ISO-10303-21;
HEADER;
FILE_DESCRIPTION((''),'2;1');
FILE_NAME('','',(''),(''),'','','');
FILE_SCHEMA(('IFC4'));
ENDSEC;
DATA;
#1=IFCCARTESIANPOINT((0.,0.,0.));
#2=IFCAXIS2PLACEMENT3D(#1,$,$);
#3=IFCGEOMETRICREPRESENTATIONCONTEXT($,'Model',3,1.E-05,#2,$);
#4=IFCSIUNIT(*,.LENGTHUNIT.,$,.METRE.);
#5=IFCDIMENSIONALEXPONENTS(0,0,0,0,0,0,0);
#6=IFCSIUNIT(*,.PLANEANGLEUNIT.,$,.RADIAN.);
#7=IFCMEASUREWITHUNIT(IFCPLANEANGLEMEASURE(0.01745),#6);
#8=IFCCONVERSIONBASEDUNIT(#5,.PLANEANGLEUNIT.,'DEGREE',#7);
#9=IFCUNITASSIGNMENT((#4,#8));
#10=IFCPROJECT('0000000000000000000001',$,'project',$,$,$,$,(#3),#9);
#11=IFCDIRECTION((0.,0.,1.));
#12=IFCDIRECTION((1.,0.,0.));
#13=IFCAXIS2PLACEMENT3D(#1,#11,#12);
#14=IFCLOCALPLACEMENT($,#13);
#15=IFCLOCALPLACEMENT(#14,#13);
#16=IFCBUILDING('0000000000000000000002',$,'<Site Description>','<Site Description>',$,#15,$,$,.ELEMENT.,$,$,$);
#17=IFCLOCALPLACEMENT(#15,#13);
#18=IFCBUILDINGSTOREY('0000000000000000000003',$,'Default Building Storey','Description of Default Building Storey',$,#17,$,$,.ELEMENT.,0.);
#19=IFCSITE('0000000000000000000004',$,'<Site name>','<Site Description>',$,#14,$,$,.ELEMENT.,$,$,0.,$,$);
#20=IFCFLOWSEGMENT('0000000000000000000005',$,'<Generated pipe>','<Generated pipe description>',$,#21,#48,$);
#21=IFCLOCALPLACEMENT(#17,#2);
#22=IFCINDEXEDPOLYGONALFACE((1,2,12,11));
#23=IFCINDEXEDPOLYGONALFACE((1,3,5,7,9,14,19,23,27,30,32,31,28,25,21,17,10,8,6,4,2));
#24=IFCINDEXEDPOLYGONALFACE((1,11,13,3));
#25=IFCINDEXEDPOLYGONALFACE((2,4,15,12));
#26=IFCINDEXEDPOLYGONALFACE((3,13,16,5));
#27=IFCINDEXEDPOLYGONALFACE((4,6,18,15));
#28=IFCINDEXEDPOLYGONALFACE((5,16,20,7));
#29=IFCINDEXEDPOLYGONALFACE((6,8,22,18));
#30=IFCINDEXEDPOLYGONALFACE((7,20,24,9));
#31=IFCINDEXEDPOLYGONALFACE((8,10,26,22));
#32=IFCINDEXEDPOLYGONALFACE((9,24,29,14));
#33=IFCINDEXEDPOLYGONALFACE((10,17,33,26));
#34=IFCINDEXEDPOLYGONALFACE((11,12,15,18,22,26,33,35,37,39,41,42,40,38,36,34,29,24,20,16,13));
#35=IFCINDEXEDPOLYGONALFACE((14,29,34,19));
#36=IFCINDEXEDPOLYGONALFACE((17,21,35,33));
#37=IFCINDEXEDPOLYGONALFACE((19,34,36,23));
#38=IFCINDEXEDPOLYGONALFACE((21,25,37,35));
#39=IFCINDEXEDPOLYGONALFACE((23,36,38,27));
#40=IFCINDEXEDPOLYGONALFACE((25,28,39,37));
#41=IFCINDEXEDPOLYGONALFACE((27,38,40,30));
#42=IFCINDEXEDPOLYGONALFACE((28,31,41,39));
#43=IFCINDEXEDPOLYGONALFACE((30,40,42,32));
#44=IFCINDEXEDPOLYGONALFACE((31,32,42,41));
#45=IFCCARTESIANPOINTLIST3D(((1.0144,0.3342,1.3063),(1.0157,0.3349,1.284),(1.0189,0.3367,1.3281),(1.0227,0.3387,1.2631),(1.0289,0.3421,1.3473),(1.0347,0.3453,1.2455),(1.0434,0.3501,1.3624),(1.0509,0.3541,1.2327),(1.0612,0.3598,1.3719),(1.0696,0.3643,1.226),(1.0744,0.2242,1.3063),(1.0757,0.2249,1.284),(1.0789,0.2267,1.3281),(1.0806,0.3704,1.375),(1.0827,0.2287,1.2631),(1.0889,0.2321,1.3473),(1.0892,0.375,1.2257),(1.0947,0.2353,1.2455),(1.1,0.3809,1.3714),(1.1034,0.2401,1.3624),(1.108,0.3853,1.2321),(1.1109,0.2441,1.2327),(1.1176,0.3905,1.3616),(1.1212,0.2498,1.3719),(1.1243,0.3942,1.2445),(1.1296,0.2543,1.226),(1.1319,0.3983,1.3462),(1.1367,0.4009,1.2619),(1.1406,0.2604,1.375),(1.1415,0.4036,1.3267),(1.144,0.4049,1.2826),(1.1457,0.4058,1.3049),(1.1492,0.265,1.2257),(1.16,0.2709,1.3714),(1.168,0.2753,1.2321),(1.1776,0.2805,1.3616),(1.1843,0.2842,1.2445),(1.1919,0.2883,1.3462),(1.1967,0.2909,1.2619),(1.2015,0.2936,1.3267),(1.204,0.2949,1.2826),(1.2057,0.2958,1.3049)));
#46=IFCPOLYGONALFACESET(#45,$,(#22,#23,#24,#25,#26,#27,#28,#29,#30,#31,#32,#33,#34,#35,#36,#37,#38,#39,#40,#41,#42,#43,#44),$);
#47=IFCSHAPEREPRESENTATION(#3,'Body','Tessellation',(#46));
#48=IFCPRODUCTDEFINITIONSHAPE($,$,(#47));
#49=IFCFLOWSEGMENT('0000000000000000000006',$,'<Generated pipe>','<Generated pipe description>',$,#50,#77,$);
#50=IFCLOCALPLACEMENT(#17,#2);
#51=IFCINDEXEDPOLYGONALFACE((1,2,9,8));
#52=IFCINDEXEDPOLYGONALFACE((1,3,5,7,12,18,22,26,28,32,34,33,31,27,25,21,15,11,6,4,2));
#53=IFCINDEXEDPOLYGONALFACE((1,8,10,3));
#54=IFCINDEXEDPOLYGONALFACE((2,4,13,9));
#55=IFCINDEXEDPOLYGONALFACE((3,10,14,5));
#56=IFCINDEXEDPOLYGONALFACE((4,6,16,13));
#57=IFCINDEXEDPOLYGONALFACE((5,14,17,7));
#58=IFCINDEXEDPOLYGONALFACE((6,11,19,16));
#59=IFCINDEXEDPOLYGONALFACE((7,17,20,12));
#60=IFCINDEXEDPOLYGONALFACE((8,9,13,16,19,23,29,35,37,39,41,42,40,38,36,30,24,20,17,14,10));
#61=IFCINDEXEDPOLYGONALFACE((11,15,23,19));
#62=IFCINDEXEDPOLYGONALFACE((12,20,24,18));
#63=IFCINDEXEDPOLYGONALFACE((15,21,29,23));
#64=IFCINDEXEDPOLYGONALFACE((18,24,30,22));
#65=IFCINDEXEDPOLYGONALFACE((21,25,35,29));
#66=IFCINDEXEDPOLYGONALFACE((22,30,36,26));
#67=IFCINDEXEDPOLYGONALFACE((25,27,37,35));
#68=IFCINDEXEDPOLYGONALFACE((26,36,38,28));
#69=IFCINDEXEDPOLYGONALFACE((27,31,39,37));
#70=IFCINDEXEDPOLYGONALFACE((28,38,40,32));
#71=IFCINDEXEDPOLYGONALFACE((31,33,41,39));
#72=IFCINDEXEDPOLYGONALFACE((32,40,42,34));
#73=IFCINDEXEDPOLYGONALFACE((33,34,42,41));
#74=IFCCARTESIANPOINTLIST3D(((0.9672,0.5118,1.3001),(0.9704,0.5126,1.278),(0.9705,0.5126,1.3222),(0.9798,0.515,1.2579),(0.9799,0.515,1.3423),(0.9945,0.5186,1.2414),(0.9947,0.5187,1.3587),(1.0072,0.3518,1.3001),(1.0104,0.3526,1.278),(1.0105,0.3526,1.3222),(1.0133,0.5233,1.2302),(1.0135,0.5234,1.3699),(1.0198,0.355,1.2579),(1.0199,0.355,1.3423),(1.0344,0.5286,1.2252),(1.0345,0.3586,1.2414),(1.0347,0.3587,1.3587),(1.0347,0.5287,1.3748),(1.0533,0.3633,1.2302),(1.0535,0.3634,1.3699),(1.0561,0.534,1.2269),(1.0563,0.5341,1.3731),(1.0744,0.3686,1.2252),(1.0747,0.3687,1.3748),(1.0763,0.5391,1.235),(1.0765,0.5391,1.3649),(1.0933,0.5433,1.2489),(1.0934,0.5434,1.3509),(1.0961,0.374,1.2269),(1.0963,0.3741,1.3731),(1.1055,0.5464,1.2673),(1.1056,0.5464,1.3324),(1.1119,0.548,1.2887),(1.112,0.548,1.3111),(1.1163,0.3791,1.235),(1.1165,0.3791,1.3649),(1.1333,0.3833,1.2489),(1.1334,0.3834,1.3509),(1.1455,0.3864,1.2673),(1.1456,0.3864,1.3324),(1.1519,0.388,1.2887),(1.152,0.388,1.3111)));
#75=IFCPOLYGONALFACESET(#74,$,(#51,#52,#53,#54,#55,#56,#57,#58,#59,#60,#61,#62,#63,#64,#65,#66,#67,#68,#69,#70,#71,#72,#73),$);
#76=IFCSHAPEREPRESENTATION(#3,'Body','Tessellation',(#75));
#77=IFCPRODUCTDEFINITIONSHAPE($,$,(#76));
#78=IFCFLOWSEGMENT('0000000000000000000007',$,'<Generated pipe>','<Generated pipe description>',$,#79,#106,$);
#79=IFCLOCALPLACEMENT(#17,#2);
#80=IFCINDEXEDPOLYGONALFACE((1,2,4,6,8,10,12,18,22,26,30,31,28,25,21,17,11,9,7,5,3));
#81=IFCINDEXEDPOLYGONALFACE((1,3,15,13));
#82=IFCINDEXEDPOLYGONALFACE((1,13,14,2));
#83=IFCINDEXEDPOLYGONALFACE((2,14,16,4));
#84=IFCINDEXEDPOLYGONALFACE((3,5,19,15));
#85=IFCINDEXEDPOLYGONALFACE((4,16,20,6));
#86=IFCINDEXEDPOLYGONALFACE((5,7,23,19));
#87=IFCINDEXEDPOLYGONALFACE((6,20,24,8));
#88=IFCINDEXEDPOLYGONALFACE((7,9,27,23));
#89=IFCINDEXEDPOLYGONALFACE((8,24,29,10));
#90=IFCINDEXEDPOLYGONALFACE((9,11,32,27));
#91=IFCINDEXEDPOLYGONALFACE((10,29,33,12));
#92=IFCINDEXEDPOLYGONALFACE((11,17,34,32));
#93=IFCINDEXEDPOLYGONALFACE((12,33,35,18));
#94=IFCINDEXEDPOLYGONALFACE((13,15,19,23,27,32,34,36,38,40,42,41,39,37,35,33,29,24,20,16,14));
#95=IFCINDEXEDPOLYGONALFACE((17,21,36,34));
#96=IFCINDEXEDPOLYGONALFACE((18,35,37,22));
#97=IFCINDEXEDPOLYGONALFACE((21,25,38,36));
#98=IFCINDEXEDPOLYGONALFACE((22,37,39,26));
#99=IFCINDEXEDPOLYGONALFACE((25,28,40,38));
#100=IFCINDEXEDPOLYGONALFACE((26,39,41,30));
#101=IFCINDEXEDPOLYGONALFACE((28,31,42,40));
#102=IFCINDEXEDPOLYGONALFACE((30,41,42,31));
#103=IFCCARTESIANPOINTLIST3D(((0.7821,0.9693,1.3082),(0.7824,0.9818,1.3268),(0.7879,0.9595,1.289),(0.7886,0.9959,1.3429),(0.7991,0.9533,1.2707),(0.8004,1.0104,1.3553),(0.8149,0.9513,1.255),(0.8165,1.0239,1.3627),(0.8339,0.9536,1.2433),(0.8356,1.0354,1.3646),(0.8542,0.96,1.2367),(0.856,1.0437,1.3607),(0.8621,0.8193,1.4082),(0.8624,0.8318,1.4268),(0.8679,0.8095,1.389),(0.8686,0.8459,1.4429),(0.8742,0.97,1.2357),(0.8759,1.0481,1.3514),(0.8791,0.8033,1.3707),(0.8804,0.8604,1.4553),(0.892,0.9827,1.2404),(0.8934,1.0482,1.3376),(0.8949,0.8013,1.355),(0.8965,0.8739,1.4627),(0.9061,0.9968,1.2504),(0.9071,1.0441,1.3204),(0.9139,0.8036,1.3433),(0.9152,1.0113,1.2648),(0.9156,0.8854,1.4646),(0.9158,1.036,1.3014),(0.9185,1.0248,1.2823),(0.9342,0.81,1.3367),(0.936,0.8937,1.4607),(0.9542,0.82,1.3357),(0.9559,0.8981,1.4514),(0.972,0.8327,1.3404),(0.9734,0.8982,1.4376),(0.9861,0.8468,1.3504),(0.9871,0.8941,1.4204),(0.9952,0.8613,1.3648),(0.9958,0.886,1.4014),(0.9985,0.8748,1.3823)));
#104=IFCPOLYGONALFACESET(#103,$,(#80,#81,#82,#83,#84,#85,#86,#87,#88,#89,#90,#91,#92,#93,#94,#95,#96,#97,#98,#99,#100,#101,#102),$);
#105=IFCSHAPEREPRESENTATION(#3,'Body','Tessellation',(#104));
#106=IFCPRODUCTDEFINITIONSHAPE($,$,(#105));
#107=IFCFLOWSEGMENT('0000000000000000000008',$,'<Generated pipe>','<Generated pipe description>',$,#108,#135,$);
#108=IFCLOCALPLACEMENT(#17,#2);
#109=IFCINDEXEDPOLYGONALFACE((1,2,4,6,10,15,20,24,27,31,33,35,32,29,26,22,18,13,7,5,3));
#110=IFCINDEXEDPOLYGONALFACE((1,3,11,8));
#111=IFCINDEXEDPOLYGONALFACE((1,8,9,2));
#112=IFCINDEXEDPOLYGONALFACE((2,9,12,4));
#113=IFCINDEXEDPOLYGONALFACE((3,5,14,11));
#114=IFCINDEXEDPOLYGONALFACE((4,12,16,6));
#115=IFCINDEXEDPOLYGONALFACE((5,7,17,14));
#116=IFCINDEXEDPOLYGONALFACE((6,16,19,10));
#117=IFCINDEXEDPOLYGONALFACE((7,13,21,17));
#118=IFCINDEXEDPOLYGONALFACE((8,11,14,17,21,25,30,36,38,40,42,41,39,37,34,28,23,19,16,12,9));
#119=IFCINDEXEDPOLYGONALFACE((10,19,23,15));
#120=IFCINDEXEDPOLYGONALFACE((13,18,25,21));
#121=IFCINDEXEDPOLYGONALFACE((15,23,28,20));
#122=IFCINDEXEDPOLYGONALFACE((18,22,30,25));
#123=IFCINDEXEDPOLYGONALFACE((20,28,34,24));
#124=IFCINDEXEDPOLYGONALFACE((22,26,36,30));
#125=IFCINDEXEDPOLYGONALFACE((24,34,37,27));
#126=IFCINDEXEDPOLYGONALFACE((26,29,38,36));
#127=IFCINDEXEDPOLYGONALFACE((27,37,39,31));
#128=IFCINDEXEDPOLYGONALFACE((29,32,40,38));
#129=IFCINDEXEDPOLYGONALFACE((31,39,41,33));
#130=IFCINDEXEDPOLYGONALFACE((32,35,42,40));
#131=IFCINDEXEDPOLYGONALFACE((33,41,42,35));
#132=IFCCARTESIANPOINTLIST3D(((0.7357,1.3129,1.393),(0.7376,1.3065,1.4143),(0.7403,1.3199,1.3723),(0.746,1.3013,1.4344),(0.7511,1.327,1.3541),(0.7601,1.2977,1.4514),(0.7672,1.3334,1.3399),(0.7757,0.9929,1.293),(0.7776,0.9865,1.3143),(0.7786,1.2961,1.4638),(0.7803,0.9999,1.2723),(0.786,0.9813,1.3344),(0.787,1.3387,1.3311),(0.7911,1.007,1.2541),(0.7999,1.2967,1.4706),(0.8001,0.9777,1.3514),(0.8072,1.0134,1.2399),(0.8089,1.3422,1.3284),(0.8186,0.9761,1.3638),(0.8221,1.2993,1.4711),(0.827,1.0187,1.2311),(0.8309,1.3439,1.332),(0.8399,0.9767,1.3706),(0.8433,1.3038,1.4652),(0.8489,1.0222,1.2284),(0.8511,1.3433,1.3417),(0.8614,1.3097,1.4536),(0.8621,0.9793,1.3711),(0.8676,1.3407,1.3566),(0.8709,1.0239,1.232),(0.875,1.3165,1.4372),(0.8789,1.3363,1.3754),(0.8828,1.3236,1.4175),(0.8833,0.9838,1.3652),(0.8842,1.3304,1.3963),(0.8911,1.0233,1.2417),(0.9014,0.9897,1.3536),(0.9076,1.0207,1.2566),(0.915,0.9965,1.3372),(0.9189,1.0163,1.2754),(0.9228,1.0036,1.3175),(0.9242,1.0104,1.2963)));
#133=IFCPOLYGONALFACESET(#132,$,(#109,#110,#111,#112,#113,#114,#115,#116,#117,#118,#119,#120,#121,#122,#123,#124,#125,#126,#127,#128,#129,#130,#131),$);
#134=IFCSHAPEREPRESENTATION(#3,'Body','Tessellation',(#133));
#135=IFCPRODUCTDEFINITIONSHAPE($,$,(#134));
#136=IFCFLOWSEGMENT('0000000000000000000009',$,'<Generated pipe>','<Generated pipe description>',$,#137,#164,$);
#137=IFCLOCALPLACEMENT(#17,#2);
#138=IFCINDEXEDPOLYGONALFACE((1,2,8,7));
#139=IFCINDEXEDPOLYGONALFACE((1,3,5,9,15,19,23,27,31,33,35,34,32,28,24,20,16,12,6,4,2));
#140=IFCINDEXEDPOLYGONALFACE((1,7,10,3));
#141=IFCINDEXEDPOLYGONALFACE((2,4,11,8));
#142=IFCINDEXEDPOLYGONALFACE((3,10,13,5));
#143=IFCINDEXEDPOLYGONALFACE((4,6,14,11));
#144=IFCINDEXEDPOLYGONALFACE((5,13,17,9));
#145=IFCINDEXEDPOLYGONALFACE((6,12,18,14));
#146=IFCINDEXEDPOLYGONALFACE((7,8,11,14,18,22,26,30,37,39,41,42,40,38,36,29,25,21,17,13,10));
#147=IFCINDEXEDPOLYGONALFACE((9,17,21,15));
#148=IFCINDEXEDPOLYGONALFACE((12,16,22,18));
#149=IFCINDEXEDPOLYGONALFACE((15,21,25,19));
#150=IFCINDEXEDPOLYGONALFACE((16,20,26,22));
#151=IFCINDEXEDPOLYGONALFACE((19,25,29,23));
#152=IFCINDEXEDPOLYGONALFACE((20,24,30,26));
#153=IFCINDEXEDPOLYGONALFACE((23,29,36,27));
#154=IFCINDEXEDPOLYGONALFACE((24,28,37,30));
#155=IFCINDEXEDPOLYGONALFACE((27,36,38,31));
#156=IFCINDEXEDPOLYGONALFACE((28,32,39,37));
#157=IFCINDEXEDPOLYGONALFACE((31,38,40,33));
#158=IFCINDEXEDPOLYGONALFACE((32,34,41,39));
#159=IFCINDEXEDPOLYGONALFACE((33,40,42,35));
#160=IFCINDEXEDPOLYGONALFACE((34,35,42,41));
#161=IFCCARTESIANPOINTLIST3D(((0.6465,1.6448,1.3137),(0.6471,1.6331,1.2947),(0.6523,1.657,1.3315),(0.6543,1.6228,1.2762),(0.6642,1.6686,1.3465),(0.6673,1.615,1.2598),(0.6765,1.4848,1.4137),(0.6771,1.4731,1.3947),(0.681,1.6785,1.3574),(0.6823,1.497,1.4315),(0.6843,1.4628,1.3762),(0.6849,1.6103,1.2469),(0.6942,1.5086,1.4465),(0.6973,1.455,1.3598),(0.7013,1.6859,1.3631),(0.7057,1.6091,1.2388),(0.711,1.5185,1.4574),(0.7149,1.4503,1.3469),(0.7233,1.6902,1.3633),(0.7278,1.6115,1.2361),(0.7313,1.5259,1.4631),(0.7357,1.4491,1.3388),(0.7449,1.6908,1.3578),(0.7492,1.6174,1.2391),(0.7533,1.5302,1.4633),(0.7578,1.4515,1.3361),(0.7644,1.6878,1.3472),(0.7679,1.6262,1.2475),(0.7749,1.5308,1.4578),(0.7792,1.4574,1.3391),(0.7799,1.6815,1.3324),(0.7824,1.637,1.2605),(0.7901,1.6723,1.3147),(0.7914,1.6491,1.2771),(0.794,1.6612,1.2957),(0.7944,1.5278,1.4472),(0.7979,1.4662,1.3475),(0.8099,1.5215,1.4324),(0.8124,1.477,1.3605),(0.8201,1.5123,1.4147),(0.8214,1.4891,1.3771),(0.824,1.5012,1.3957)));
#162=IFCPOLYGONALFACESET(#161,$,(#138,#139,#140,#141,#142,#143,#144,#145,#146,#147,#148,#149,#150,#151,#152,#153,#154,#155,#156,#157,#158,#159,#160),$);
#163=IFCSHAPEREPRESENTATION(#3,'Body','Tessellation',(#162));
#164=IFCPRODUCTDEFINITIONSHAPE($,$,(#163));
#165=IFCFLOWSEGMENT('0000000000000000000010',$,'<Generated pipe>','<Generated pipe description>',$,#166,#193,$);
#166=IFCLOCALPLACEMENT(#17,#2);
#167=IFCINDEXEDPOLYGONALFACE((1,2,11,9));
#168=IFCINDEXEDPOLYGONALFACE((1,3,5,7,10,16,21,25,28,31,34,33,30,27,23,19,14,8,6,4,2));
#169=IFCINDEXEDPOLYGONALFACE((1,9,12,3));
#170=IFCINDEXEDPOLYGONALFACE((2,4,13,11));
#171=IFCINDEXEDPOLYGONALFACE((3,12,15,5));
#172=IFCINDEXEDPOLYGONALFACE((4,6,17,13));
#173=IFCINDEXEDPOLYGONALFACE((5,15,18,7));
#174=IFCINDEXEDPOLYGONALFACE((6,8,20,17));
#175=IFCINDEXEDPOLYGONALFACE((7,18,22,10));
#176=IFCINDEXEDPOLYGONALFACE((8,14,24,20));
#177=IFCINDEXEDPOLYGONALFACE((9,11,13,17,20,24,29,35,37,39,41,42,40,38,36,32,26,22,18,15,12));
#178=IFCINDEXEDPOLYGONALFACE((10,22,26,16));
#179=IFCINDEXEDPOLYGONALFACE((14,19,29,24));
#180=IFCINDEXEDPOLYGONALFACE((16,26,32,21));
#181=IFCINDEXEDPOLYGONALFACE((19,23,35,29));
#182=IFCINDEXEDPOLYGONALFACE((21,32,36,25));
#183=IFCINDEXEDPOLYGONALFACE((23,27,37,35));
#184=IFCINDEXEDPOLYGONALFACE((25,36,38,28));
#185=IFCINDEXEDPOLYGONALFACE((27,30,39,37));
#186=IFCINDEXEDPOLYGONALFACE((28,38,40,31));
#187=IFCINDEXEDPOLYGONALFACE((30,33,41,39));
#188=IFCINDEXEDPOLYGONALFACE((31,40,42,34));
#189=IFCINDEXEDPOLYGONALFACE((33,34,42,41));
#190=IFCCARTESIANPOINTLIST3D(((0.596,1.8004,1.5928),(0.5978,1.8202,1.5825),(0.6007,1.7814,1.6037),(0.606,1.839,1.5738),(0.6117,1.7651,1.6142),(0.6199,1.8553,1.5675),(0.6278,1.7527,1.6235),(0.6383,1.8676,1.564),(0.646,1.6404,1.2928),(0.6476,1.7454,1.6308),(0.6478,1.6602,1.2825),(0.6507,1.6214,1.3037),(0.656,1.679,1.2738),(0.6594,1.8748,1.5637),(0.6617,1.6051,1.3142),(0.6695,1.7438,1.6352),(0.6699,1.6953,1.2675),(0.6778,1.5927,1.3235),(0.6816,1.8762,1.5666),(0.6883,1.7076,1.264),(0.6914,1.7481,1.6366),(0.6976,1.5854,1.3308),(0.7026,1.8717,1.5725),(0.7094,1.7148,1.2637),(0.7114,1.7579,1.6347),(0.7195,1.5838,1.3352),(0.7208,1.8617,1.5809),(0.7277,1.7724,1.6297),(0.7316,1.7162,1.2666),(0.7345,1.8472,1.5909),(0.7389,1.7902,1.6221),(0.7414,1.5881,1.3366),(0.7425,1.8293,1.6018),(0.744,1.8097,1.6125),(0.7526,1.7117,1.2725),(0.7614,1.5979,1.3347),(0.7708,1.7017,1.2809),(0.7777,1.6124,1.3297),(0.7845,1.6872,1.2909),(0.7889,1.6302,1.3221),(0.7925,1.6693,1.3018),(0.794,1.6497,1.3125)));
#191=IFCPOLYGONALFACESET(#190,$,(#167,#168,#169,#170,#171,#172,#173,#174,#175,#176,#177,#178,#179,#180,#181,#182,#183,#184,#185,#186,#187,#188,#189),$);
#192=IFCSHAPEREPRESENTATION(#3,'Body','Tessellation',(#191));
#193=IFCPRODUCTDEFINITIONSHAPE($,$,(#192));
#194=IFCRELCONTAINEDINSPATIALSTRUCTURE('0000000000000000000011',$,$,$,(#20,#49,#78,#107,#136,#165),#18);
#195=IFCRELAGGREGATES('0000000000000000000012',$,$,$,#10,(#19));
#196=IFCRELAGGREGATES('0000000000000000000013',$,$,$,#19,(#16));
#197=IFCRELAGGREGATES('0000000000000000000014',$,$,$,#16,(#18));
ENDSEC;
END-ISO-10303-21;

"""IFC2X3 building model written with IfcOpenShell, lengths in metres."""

from ifc_helpers import new_model, entity, si_unit, converted_unit, frame, origin, origin_with_axes, origin_2d_with_axis, place, context, project, spatial, circle, extrude, element, save


model = new_model("IFC2X3")

# Units and contexts
model_context = context("Model", 3, precision=1e-05, world=origin())
ifc_project = project(units=[si_unit("LENGTHUNIT", "METRE"), converted_unit("PLANEANGLEUNIT", "DEGREE", entity("IfcPlaneAngleMeasure", 0.01745), si_unit("PLANEANGLEUNIT", "RADIAN"), dimensions=[0, 0, 0, 0, 0, 0, 0])], contexts=[model_context])

# Site, building, storey
site_placement = place(None, origin_with_axes())
site = spatial("IfcSite", under=ifc_project, at=site_placement, Name="<Site name>", Description="<Site Description>", CompositionType="ELEMENT", RefElevation=0.0)
building_placement = place(site_placement, origin_with_axes())
building = spatial("IfcBuilding", under=site, at=building_placement, Name="<Site Description>", Description="<Site Description>", CompositionType="ELEMENT")
storey_placement = place(building_placement, origin_with_axes())
storey = spatial("IfcBuildingStorey", under=building, at=storey_placement, Name="Default Building Storey", Description="Description of Default Building Storey", CompositionType="ELEMENT", Elevation=0.0)

# Flow segments
flow_segment_1_placement = place(storey_placement, frame((1.14, 0.26, 1.3), z_axis=(-0.478852, 0.877896, 0.0), x_axis=(0.820309, 0.447441, 0.356216)))
element("IfcFlowSegment", 1, at=flow_segment_1_placement, inside=storey, Name="<Generated pipe>", Description="<Generated pipe description>", context=model_context, shape_type="SweptSolid", body=[
    extrude(circle(Radius=0.075, at=origin_2d_with_axis()), origin_with_axes(), (0.0, 0.0, 1.0), 0.1253),
])
flow_segment_2_placement = place(storey_placement, frame((1.08, 0.37, 1.3), z_axis=(-0.242536, 0.970143, 0.0), x_axis=(0.712227, 0.178057, 0.678991)))
element("IfcFlowSegment", 2, at=flow_segment_2_placement, inside=storey, Name="<Generated pipe>", Description="<Generated pipe description>", context=model_context, shape_type="SweptSolid", body=[
    extrude(circle(Radius=0.075, at=origin_2d_with_axis()), origin_with_axes(), (0.0, 0.0, 1.0), 0.1649),
])
flow_segment_3_placement = place(storey_placement, frame((0.93, 0.85, 1.4), z_axis=(-0.405616, 0.76053, -0.50702), x_axis=(0.345063, 0.641063, 0.685544)))
element("IfcFlowSegment", 3, at=flow_segment_3_placement, inside=storey, Name="<Generated pipe>", Description="<Generated pipe description>", context=model_context, shape_type="SweptSolid", body=[
    extrude(circle(Radius=0.075, at=origin_2d_with_axis()), origin_with_axes(), (0.0, 0.0, 1.0), 0.1972),
])
flow_segment_4_placement = place(storey_placement, frame((0.85, 1.0, 1.3), z_axis=(-0.11847, 0.947758, 0.296174), x_axis=(0.685638, -0.137672, 0.714806)))
element("IfcFlowSegment", 4, at=flow_segment_4_placement, inside=storey, Name="<Generated pipe>", Description="<Generated pipe description>", context=model_context, shape_type="SweptSolid", body=[
    extrude(circle(Radius=0.075, at=origin_2d_with_axis()), origin_with_axes(), (0.0, 0.0, 1.0), 0.3376),
])
flow_segment_5_placement = place(storey_placement, frame((0.75, 1.49, 1.4), z_axis=(-0.157027, 0.837478, -0.523424), x_axis=(0.043654, 0.535367, 0.843491)))
element("IfcFlowSegment", 5, at=flow_segment_5_placement, inside=storey, Name="<Generated pipe>", Description="<Generated pipe description>", context=model_context, shape_type="SweptSolid", body=[
    extrude(circle(Radius=0.075, at=origin_2d_with_axis()), origin_with_axes(), (0.0, 0.0, 1.0), 0.191),
])
flow_segment_6_placement = place(storey_placement, frame((0.72, 1.65, 1.3), z_axis=(-0.145494, 0.465581, 0.872964), x_axis=(0.966024, 0.257359, 0.023746)))
element("IfcFlowSegment", 6, at=flow_segment_6_placement, inside=storey, Name="<Generated pipe>", Description="<Generated pipe description>", context=model_context, shape_type="SweptSolid", body=[
    extrude(circle(Radius=0.075, at=origin_2d_with_axis()), origin_with_axes(), (0.0, 0.0, 1.0), 0.3437),
])

save(model, "model.ifc")
